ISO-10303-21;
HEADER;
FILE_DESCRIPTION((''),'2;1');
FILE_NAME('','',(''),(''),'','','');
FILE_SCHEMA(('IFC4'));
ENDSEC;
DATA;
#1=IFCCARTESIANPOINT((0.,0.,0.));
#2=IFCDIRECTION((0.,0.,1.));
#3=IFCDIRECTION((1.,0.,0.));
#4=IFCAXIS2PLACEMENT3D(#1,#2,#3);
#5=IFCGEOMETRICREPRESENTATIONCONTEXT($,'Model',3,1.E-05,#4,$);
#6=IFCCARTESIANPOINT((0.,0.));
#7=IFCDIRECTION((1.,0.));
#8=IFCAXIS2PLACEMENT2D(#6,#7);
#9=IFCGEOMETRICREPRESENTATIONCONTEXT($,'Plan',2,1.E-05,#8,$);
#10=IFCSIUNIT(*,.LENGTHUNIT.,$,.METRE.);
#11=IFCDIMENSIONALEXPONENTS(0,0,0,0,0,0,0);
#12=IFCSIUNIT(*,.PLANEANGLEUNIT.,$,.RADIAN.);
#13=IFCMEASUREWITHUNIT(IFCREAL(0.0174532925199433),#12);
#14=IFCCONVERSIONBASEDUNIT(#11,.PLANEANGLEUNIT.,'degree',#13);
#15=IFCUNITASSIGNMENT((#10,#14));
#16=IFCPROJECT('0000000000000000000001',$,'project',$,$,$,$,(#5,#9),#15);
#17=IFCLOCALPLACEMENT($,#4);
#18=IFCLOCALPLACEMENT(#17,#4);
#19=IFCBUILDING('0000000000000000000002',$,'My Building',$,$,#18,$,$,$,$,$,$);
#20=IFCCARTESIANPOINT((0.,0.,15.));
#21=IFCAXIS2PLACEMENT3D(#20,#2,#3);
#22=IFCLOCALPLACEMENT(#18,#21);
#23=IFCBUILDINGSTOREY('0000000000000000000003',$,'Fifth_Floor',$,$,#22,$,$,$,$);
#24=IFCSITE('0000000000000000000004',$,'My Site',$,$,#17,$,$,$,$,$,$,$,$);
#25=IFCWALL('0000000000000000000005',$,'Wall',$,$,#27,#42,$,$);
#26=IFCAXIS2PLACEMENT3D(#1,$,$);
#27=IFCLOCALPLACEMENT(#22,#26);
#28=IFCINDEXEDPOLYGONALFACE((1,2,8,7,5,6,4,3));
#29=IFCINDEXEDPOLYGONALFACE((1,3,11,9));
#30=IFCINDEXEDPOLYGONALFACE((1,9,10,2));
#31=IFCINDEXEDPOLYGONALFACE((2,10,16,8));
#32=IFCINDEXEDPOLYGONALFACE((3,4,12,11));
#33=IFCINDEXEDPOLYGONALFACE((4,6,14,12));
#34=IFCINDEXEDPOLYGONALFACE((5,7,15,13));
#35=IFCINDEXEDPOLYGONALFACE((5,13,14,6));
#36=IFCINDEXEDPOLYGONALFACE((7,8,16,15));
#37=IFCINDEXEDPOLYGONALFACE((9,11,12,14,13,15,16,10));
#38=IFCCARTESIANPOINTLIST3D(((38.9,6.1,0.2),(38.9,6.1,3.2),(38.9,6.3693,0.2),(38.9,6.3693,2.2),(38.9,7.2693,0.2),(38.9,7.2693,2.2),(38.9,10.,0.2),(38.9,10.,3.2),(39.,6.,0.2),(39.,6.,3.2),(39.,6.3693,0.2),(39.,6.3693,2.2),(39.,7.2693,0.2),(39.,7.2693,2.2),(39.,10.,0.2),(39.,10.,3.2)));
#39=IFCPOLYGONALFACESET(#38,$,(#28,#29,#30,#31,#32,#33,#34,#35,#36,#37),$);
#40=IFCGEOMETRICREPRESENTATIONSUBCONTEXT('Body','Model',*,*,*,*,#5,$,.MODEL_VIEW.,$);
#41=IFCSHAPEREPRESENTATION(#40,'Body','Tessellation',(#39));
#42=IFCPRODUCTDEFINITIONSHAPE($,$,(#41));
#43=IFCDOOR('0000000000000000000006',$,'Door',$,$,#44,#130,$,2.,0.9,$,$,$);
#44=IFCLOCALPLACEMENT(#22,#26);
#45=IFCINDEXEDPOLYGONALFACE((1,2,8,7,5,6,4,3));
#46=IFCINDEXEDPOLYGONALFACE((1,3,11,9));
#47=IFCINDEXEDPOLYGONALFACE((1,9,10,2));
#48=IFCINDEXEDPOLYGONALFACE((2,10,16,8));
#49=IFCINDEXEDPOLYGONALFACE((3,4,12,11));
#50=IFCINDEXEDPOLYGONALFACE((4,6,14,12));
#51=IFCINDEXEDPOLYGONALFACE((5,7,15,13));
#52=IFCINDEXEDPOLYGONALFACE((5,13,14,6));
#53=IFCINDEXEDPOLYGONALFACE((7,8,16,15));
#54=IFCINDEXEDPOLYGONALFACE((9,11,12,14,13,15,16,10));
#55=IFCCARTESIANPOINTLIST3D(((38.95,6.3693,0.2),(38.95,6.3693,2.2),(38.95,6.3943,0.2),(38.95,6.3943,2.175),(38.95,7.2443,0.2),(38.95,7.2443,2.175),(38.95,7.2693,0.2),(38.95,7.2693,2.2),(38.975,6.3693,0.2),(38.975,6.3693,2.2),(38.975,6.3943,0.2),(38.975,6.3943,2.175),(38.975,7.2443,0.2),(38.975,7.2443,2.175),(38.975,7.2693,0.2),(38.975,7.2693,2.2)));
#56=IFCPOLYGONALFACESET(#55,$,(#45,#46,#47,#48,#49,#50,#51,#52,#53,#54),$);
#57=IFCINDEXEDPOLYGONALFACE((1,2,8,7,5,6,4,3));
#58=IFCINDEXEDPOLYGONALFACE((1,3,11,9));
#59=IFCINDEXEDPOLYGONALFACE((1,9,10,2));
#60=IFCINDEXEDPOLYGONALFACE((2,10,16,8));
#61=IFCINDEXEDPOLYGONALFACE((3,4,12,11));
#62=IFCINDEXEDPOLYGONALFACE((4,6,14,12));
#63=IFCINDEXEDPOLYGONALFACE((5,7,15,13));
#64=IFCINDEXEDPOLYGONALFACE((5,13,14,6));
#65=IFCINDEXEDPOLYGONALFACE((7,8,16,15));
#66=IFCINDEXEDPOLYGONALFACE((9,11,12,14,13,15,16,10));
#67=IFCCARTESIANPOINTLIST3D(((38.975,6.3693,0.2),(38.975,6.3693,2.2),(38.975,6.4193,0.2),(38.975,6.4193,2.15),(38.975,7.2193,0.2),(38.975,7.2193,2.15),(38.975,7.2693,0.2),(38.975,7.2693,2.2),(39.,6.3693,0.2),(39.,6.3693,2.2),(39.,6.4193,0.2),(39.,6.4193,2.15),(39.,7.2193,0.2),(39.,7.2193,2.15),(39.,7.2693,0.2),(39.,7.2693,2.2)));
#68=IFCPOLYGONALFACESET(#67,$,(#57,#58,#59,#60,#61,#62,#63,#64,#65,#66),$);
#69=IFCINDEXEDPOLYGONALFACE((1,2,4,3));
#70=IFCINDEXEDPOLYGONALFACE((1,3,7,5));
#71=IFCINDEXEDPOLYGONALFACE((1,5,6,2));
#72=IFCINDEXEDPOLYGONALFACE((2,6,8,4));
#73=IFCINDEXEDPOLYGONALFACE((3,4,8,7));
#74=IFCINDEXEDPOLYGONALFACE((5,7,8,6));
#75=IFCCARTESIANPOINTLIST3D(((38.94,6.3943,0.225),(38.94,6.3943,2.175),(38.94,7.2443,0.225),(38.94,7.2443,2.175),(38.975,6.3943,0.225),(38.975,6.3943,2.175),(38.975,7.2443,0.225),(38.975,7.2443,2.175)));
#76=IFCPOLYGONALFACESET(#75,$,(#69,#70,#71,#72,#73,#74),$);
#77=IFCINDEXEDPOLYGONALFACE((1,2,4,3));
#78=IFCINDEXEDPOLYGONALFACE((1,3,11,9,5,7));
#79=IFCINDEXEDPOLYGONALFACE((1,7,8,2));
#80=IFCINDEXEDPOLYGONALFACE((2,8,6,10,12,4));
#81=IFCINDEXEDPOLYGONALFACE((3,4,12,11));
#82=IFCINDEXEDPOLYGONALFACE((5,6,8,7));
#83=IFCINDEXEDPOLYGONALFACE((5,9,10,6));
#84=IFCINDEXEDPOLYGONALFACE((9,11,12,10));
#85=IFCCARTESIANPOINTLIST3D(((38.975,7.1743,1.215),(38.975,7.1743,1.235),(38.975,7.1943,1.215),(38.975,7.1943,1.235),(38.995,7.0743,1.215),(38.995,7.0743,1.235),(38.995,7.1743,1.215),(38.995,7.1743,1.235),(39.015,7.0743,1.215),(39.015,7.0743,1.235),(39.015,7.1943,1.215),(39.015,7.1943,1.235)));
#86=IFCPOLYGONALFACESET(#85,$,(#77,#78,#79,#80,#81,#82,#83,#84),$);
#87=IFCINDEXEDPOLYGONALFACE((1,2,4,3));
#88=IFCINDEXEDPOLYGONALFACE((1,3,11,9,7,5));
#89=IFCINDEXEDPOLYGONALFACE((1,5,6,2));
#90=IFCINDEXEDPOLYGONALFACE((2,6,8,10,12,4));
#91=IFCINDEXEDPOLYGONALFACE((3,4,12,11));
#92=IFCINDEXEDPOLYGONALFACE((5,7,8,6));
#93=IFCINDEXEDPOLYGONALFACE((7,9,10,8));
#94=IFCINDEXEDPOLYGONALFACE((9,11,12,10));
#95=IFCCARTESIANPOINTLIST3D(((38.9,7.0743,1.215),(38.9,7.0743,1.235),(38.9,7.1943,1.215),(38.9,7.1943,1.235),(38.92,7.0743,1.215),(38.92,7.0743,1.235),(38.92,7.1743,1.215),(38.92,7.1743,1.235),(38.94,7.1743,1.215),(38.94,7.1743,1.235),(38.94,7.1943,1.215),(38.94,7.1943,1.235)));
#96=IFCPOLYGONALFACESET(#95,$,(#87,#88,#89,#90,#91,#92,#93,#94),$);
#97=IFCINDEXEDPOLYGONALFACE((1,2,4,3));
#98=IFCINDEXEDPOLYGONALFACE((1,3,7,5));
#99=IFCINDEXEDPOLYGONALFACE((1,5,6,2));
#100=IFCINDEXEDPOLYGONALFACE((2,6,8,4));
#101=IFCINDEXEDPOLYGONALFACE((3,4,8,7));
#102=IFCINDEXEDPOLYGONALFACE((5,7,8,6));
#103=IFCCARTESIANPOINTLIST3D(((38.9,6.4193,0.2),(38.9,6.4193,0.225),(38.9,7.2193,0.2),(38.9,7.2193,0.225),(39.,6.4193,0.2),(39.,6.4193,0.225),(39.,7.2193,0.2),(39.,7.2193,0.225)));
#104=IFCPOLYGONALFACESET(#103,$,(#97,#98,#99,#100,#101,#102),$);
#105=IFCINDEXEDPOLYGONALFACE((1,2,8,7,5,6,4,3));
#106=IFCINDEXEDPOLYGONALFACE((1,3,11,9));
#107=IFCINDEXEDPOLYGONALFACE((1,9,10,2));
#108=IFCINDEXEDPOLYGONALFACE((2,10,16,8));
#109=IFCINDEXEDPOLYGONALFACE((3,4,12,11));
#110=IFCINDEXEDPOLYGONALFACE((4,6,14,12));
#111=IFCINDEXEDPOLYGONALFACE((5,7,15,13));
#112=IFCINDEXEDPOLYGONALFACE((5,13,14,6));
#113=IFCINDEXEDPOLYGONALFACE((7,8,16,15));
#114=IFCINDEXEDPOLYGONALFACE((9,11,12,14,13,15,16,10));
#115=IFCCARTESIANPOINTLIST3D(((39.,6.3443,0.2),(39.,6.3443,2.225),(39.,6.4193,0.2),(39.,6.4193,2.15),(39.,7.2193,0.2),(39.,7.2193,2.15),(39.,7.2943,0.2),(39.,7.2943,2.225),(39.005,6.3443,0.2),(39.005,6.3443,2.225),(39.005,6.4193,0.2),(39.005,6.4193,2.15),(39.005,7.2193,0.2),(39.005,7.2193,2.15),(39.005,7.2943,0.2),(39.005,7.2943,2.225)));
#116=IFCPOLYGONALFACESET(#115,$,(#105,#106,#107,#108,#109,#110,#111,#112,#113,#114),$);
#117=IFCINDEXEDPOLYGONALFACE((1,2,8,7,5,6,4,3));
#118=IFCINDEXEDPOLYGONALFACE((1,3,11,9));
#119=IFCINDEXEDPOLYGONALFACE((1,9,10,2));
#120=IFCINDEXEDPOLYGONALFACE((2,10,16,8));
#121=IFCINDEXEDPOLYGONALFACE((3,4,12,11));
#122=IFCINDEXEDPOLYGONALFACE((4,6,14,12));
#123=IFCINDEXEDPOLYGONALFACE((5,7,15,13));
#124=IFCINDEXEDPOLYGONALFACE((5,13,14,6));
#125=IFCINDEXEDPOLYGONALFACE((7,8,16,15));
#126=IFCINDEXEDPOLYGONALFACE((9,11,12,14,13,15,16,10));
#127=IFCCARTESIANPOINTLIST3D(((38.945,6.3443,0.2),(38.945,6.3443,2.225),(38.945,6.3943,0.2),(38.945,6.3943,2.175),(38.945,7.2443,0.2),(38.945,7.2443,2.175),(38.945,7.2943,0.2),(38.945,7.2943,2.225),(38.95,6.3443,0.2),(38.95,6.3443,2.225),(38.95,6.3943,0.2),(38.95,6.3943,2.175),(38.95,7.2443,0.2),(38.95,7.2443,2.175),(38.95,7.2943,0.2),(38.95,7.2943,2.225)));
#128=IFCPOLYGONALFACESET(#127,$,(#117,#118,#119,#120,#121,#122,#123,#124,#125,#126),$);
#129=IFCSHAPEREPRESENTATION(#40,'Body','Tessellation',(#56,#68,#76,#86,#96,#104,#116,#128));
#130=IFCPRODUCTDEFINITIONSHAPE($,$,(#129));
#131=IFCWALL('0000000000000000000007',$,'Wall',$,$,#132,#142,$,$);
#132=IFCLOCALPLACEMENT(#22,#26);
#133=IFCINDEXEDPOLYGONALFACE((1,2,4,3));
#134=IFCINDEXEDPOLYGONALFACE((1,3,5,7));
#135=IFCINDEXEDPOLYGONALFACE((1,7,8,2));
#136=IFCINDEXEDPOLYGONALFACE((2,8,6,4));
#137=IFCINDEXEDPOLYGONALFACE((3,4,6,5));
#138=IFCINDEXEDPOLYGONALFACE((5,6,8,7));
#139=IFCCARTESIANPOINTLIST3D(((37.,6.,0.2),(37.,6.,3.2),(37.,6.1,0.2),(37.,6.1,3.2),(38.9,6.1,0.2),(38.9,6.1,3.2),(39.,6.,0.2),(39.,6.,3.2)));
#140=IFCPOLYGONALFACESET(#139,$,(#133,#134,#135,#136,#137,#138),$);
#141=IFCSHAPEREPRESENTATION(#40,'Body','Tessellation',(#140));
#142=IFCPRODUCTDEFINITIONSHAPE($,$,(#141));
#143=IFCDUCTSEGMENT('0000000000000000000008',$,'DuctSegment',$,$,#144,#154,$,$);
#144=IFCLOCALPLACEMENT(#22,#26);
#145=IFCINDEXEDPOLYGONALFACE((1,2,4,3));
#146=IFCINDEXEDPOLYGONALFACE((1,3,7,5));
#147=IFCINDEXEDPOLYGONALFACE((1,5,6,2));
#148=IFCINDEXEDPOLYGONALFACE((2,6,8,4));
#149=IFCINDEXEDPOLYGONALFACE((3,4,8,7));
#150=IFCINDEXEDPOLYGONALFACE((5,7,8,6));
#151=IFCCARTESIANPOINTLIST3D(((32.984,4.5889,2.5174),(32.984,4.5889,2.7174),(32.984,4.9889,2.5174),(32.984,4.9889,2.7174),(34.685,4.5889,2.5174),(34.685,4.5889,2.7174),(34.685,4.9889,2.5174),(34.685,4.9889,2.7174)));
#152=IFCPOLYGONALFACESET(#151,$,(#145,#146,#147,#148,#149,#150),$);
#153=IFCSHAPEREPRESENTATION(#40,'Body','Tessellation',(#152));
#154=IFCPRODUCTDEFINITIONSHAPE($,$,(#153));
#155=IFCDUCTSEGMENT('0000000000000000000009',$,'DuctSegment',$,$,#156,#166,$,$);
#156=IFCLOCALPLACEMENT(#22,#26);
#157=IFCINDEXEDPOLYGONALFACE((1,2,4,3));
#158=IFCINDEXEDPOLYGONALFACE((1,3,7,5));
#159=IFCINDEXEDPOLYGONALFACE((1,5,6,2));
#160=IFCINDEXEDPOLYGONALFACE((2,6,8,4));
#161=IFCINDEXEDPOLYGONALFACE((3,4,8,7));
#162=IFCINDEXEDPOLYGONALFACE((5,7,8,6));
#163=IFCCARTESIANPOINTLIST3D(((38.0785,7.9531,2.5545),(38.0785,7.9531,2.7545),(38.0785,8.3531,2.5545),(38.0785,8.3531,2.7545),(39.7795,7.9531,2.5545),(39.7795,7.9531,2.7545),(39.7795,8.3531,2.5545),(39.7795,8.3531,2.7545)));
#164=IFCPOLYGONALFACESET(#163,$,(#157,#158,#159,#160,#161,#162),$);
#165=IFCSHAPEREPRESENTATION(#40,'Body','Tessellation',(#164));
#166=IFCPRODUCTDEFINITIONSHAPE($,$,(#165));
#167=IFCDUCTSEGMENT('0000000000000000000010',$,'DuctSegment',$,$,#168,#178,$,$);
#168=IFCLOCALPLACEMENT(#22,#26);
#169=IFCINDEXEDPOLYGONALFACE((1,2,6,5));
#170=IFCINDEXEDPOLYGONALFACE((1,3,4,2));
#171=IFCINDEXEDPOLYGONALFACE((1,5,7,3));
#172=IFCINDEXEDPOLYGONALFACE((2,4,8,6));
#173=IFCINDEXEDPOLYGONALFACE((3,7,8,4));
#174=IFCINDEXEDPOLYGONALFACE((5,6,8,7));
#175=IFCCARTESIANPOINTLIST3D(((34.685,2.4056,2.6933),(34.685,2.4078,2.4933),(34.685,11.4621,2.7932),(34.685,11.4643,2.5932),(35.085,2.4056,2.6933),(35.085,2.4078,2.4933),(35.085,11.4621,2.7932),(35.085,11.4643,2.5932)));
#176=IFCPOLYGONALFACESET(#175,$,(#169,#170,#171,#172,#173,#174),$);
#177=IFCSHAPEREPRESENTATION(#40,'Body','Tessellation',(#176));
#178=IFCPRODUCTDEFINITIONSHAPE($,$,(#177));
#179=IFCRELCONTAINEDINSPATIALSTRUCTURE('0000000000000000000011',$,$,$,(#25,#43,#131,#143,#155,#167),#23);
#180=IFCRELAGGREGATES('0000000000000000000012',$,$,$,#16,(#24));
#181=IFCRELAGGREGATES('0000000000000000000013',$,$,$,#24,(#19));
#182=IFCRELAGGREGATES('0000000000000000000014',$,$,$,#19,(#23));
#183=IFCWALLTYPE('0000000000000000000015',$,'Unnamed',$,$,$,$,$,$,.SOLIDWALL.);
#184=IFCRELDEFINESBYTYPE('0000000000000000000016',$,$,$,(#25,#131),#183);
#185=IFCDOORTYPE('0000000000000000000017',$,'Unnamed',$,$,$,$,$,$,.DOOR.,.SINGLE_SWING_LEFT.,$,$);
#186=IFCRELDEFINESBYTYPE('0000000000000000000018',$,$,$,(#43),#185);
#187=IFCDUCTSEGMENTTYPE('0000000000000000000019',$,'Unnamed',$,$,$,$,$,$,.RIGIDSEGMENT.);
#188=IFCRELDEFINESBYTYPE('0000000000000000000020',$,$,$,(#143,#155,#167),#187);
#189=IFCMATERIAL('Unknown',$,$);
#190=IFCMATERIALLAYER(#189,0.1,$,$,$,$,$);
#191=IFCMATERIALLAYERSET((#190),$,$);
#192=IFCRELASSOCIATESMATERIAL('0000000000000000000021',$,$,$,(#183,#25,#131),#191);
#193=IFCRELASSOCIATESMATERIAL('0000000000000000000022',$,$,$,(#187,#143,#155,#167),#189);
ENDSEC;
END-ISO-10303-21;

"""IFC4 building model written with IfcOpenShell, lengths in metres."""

from ifc_helpers import new_model, entity, si_unit, converted_unit, frame, origin_with_axes, origin_2d_with_axis, place, context, subcontext, project, spatial, line, indexed_curve, rectangle, outline, extrude, shape, source, transform, mapped, material, layer, layer_set, layer_usage, material_profile, profile_set, profile_usage, type_object, type_shapes, element, fill, save


model = new_model("IFC4")

# Units and contexts
model_context = context("Model", 3, precision=1e-05, world=origin_with_axes())
plan_context = context("Plan", 2, precision=1e-05, world=origin_2d_with_axis())
body_context_1 = subcontext(model_context, "Body", "Model", "MODEL_VIEW")
body_context_2 = subcontext(plan_context, "Body", "Plan", "PLAN_VIEW")
ifc_project = project(units=[si_unit("LENGTHUNIT", "METRE"), converted_unit("PLANEANGLEUNIT", "degree", entity("IfcReal", 0.0174532925199433), si_unit("PLANEANGLEUNIT", "RADIAN"), dimensions=[0, 0, 0, 0, 0, 0, 0])], contexts=[model_context, plan_context])

# Site, building, storey
site_placement = place(None, origin_with_axes())
site = spatial("IfcSite", under=ifc_project, at=site_placement, Name="My Site")
building_placement = place(site_placement, origin_with_axes())
building = spatial("IfcBuilding", under=site, at=building_placement, Name="My Building")
storey_placement = place(building_placement, frame((0.0, 0.0, 15.0), z_axis=(0.0, 0.0, 1.0), x_axis=(1.0, 0.0, 0.0)))
storey = spatial("IfcBuildingStorey", under=building, at=storey_placement, Name="Fifth_Floor")

# Shared definitions
ifc_material = material(Name="Unknown")
ifc_layer = layer(ifc_material, 0.1)
ifc_layer_set = layer_set([ifc_layer])
wall_type = type_object("IfcWallType", Name="Unnamed", PredefinedType="SOLIDWALL", material=ifc_layer_set)
shared_shape_1 = source(origin_with_axes(), body_context_1, "Body", "SweptSolid", [
    extrude(outline(indexed_curve([(0.0, 0.0), (0.9, 0.0), (0.9, 2.0), (0.0, 2.0)], segments=[line(1, 2, 3, 4, 1)])), frame((0.0, -0.6, 0.0), z_axis=(0.0, -1.0, 0.0), x_axis=(1.0, 0.0, 0.0)), (0.0, 0.0, -1.0), 1.2),
])
door_type = type_object("IfcDoorType", Name="Unnamed", OperationType="SINGLE_SWING_LEFT", PredefinedType="DOOR")
shared_shape_2 = source(origin_with_axes(), body_context_1, "Body", "SweptSolid", [
    extrude(outline(indexed_curve([(0.0, 0.0), (0.0, 2.0), (0.9, 2.0), (0.9, 0.0), (0.875, 0.0), (0.875, 1.975), (0.025, 1.975), (0.025, 0.0)], segments=[line(1, 2, 3, 4, 5, 6, 7, 8, 1)])), frame((0.0, 0.025, 0.0), z_axis=(0.0, -1.0, 0.0), x_axis=(1.0, 0.0, 0.0)), (0.0, 0.0, -1.0), 0.025),
    extrude(outline(indexed_curve([(0.0, 0.0), (0.0, 2.0), (0.9, 2.0), (0.9, 0.0), (0.85, 0.0), (0.85, 1.95), (0.05, 1.95), (0.05, 0.0)], segments=[line(1, 2, 3, 4, 5, 6, 7, 8, 1)])), frame((0.0, 0.0, 0.0), z_axis=(0.0, -1.0, 0.0), x_axis=(1.0, 0.0, 0.0)), (0.0, 0.0, -1.0), 0.025),
    extrude(outline(indexed_curve([(0.0, 0.0), (0.85, 0.0), (0.85, 0.035), (0.0, 0.035)], segments=[line(1, 2, 3, 4, 1)])), frame((0.025, 0.025, 0.025), z_axis=(0.0, 0.0, 1.0), x_axis=(1.0, 0.0, 0.0)), (0.0, 0.0, 1.0), 1.95),
    extrude(outline(indexed_curve([(0.0, 0.0), (0.0, -0.04), (-0.12, -0.04), (-0.12, -0.02), (-0.02, -0.02), (-0.02, 0.0)], segments=[line(1, 2, 3, 4, 5, 6, 1)])), frame((0.825, 0.025, 1.015), z_axis=(0.0, 0.0, 1.0), x_axis=(1.0, 0.0, 0.0)), (0.0, 0.0, 1.0), 0.02),
    extrude(outline(indexed_curve([(0.0, 0.0), (0.0, 0.04), (-0.12, 0.04), (-0.12, 0.02), (-0.02, 0.02), (-0.02, 0.0)], segments=[line(1, 2, 3, 4, 5, 6, 1)])), frame((0.825, 0.06, 1.015), z_axis=(0.0, 0.0, 1.0), x_axis=(1.0, 0.0, 0.0)), (0.0, 0.0, 1.0), 0.02),
    extrude(outline(indexed_curve([(0.0, 0.0), (0.8, 0.0), (0.8, 0.1), (0.0, 0.1)], segments=[line(1, 2, 3, 4, 1)])), frame((0.05, 0.0, 0.0), z_axis=(0.0, 0.0, 1.0), x_axis=(1.0, 0.0, 0.0)), (0.0, 0.0, 1.0), 0.025),
    extrude(outline(indexed_curve([(0.0, 0.0), (0.0, 2.025), (0.95, 2.025), (0.95, 0.0), (0.875, 0.0), (0.875, 1.95), (0.075, 1.95), (0.075, 0.0)], segments=[line(1, 2, 3, 4, 5, 6, 7, 8, 1)])), frame((-0.025, -0.005, 0.0), z_axis=(0.0, -1.0, 0.0), x_axis=(1.0, 0.0, 0.0)), (0.0, 0.0, -1.0), 0.005),
    extrude(outline(indexed_curve([(0.0, 0.0), (0.0, 2.025), (0.95, 2.025), (0.95, 0.0), (0.9, 0.0), (0.9, 1.975), (0.05, 1.975), (0.05, 0.0)], segments=[line(1, 2, 3, 4, 5, 6, 7, 8, 1)])), frame((-0.025, 0.05, 0.0), z_axis=(0.0, -1.0, 0.0), x_axis=(1.0, 0.0, 0.0)), (0.0, 0.0, -1.0), 0.005),
])
shared_shape_3 = source(origin_with_axes(), body_context_2, "Body", "Curve2D", [
    entity("IfcIndexedPolyCurve", entity("IfcCartesianPointList2D", [[0.0, 0.0], [0.0, 0.05], [0.025, 0.05], [0.025, 0.025], [0.05, 0.025], [0.05, 0.0]]), [entity("IfcLineIndex", [1, 2, 3, 4, 5, 6, 1])]),
    entity("IfcIndexedPolyCurve", entity("IfcCartesianPointList2D", [[0.9, 0.0], [0.9, 0.05], [0.875, 0.05], [0.875, 0.025], [0.85, 0.025], [0.85, 0.0]]), [entity("IfcLineIndex", [1, 2, 3, 4, 5, 6, 1])]),
    entity("IfcTrimmedCurve", entity("IfcEllipse", entity("IfcAxis2Placement2D", entity("IfcCartesianPoint", [0.06, 0.05]), entity("IfcDirection", [1.0, 0.0])), 0.815, 0.85), [entity("IfcCartesianPoint", [0.875, 0.05])], [entity("IfcCartesianPoint", [0.06, 0.9])], True, "CARTESIAN"),
    entity("IfcIndexedPolyCurve", entity("IfcCartesianPointList2D", [[0.025, 0.05], [0.06, 0.05], [0.06, 0.9], [0.025, 0.9]]), [entity("IfcLineIndex", [1, 2, 3, 4, 1])]),
])
type_shapes(door_type, [shared_shape_2, shared_shape_3])

# Wall, opening, door
ifc_layer_usage_1 = layer_usage(ifc_layer_set, "AXIS2", "POSITIVE", 0.0)
wall_1_placement = place(storey_placement, frame((39.0, 6.0, 0.2), z_axis=(0.0, 0.0, 1.0), x_axis=(0.0, 1.0, 0.0)))
wall_1 = element("IfcWall", 1, at=wall_1_placement, inside=storey, type_object=wall_type, material=ifc_layer_usage_1, Name="Wall", context=body_context_1, shape_type="SweptSolid", body=[
    extrude(outline(indexed_curve([(0.0, 0.0), (0.1, 0.1), (4.0, 0.1), (4.0, 0.0)], segments=[line(1, 2, 3, 4, 1)])), origin_with_axes(), (0.0, 0.0, 1.0), 3.0),
])
opening_1_placement = place(wall_1_placement, frame((0.3693, 0.0, 0.0), z_axis=(0.0, 0.0, 1.0), x_axis=(1.0, 0.0, 0.0)))
opening_1 = element("IfcOpeningElement", 2, at=opening_1_placement, cuts=wall_1, PredefinedType="OPENING", context=body_context_1, shape_type="MappedRepresentation", body=[
    mapped(shared_shape_1, transform((0.0, 0.0, 0.0), x_axis=(1.0, 0.0, 0.0), y_axis=(0.0, 1.0, 0.0), z_axis=(0.0, 0.0, 1.0), scale=1.0)),
])
door_1_placement = place(opening_1_placement, frame((0.0, 0.0, 0.0), z_axis=(0.0, 0.0, 1.0), x_axis=(1.0, 0.0, 0.0)))
door_1 = element("IfcDoor", 3, at=door_1_placement, inside=storey, type_object=door_type, Name="Door", OverallHeight=2.0, OverallWidth=0.9, shapes=[
    shape(body_context_1, "Body", "MappedRepresentation", [mapped(shared_shape_2, transform((0.0, 0.0, 0.0), x_axis=(1.0, 0.0, 0.0), y_axis=(0.0, 1.0, 0.0), z_axis=(0.0, 0.0, 1.0), scale=1.0))]),
    shape(body_context_2, "Body", "MappedRepresentation", [mapped(shared_shape_3, transform((0.0, 0.0, 0.0), x_axis=(1.0, 0.0, 0.0), y_axis=(0.0, 1.0, 0.0), z_axis=(0.0, 0.0, 1.0), scale=1.0))]),
])
fill(opening_1, door_1)

# Wall
ifc_layer_usage_2 = layer_usage(ifc_layer_set, "AXIS2", "POSITIVE", 0.0)
wall_2_placement = place(storey_placement, frame((37.0, 6.0, 0.2), z_axis=(0.0, 0.0, 1.0), x_axis=(1.0, 0.0, 0.0)))
element("IfcWall", 4, at=wall_2_placement, inside=storey, type_object=wall_type, material=ifc_layer_usage_2, Name="Wall", context=body_context_1, shape_type="SweptSolid", body=[
    extrude(outline(indexed_curve([(0.0, 0.0), (0.0, 0.1), (1.9, 0.1), (2.0, 0.0)], segments=[line(1, 2, 3, 4, 1)])), origin_with_axes(), (0.0, 0.0, 1.0), 3.0),
])

# Duct segments
ifc_material_profile_1 = material_profile(ifc_material, rectangle(XDim=0.4, YDim=0.2))
ifc_profile_set_1 = profile_set([ifc_material_profile_1])
ifc_profile_usage_1 = profile_usage(ifc_profile_set_1, cardinal=5)
duct_segment_type = type_object("IfcDuctSegmentType", Name="Unnamed", PredefinedType="RIGIDSEGMENT", material=ifc_profile_set_1)
duct_segment_1_placement = place(storey_placement, frame((34.685, 4.7889, 2.6174), z_axis=(-1.0, 0.000001, 0.000001), x_axis=(-0.000001, -1.0, 0.0)))
element("IfcDuctSegment", 5, at=duct_segment_1_placement, inside=storey, type_object=duct_segment_type, material=ifc_profile_usage_1, Name="DuctSegment", context=body_context_1, shape_type="SweptSolid", body=[
    extrude(rectangle(XDim=0.4, YDim=0.2), origin_with_axes(), (0.0, 0.0, 1.0), 1.701),
])
ifc_profile_usage_2 = profile_usage(ifc_profile_set_1, cardinal=5)
duct_segment_2_placement = place(storey_placement, frame((39.7795, 8.1531, 2.6545), z_axis=(-1.0, 0.000001, 0.000001), x_axis=(-0.000001, -1.0, 0.0)))
element("IfcDuctSegment", 6, at=duct_segment_2_placement, inside=storey, type_object=duct_segment_type, material=ifc_profile_usage_2, Name="DuctSegment", context=body_context_1, shape_type="SweptSolid", body=[
    extrude(rectangle(XDim=0.4, YDim=0.2), origin_with_axes(), (0.0, 0.0, 1.0), 1.701),
])
ifc_profile_usage_3 = profile_usage(ifc_profile_set_1, cardinal=5)
duct_segment_3_placement = place(storey_placement, frame((34.885, 2.4067, 2.5933), z_axis=(0.0, 0.999939, 0.011037), x_axis=(-1.0, 0.0, 0.0)))
element("IfcDuctSegment", 7, at=duct_segment_3_placement, inside=storey, type_object=duct_segment_type, material=ifc_profile_usage_3, Name="DuctSegment", context=body_context_1, shape_type="SweptSolid", body=[
    extrude(rectangle(XDim=0.4, YDim=0.2), origin_with_axes(), (0.0, 0.0, 1.0), 9.057),
])

save(model, "model.ifc")
